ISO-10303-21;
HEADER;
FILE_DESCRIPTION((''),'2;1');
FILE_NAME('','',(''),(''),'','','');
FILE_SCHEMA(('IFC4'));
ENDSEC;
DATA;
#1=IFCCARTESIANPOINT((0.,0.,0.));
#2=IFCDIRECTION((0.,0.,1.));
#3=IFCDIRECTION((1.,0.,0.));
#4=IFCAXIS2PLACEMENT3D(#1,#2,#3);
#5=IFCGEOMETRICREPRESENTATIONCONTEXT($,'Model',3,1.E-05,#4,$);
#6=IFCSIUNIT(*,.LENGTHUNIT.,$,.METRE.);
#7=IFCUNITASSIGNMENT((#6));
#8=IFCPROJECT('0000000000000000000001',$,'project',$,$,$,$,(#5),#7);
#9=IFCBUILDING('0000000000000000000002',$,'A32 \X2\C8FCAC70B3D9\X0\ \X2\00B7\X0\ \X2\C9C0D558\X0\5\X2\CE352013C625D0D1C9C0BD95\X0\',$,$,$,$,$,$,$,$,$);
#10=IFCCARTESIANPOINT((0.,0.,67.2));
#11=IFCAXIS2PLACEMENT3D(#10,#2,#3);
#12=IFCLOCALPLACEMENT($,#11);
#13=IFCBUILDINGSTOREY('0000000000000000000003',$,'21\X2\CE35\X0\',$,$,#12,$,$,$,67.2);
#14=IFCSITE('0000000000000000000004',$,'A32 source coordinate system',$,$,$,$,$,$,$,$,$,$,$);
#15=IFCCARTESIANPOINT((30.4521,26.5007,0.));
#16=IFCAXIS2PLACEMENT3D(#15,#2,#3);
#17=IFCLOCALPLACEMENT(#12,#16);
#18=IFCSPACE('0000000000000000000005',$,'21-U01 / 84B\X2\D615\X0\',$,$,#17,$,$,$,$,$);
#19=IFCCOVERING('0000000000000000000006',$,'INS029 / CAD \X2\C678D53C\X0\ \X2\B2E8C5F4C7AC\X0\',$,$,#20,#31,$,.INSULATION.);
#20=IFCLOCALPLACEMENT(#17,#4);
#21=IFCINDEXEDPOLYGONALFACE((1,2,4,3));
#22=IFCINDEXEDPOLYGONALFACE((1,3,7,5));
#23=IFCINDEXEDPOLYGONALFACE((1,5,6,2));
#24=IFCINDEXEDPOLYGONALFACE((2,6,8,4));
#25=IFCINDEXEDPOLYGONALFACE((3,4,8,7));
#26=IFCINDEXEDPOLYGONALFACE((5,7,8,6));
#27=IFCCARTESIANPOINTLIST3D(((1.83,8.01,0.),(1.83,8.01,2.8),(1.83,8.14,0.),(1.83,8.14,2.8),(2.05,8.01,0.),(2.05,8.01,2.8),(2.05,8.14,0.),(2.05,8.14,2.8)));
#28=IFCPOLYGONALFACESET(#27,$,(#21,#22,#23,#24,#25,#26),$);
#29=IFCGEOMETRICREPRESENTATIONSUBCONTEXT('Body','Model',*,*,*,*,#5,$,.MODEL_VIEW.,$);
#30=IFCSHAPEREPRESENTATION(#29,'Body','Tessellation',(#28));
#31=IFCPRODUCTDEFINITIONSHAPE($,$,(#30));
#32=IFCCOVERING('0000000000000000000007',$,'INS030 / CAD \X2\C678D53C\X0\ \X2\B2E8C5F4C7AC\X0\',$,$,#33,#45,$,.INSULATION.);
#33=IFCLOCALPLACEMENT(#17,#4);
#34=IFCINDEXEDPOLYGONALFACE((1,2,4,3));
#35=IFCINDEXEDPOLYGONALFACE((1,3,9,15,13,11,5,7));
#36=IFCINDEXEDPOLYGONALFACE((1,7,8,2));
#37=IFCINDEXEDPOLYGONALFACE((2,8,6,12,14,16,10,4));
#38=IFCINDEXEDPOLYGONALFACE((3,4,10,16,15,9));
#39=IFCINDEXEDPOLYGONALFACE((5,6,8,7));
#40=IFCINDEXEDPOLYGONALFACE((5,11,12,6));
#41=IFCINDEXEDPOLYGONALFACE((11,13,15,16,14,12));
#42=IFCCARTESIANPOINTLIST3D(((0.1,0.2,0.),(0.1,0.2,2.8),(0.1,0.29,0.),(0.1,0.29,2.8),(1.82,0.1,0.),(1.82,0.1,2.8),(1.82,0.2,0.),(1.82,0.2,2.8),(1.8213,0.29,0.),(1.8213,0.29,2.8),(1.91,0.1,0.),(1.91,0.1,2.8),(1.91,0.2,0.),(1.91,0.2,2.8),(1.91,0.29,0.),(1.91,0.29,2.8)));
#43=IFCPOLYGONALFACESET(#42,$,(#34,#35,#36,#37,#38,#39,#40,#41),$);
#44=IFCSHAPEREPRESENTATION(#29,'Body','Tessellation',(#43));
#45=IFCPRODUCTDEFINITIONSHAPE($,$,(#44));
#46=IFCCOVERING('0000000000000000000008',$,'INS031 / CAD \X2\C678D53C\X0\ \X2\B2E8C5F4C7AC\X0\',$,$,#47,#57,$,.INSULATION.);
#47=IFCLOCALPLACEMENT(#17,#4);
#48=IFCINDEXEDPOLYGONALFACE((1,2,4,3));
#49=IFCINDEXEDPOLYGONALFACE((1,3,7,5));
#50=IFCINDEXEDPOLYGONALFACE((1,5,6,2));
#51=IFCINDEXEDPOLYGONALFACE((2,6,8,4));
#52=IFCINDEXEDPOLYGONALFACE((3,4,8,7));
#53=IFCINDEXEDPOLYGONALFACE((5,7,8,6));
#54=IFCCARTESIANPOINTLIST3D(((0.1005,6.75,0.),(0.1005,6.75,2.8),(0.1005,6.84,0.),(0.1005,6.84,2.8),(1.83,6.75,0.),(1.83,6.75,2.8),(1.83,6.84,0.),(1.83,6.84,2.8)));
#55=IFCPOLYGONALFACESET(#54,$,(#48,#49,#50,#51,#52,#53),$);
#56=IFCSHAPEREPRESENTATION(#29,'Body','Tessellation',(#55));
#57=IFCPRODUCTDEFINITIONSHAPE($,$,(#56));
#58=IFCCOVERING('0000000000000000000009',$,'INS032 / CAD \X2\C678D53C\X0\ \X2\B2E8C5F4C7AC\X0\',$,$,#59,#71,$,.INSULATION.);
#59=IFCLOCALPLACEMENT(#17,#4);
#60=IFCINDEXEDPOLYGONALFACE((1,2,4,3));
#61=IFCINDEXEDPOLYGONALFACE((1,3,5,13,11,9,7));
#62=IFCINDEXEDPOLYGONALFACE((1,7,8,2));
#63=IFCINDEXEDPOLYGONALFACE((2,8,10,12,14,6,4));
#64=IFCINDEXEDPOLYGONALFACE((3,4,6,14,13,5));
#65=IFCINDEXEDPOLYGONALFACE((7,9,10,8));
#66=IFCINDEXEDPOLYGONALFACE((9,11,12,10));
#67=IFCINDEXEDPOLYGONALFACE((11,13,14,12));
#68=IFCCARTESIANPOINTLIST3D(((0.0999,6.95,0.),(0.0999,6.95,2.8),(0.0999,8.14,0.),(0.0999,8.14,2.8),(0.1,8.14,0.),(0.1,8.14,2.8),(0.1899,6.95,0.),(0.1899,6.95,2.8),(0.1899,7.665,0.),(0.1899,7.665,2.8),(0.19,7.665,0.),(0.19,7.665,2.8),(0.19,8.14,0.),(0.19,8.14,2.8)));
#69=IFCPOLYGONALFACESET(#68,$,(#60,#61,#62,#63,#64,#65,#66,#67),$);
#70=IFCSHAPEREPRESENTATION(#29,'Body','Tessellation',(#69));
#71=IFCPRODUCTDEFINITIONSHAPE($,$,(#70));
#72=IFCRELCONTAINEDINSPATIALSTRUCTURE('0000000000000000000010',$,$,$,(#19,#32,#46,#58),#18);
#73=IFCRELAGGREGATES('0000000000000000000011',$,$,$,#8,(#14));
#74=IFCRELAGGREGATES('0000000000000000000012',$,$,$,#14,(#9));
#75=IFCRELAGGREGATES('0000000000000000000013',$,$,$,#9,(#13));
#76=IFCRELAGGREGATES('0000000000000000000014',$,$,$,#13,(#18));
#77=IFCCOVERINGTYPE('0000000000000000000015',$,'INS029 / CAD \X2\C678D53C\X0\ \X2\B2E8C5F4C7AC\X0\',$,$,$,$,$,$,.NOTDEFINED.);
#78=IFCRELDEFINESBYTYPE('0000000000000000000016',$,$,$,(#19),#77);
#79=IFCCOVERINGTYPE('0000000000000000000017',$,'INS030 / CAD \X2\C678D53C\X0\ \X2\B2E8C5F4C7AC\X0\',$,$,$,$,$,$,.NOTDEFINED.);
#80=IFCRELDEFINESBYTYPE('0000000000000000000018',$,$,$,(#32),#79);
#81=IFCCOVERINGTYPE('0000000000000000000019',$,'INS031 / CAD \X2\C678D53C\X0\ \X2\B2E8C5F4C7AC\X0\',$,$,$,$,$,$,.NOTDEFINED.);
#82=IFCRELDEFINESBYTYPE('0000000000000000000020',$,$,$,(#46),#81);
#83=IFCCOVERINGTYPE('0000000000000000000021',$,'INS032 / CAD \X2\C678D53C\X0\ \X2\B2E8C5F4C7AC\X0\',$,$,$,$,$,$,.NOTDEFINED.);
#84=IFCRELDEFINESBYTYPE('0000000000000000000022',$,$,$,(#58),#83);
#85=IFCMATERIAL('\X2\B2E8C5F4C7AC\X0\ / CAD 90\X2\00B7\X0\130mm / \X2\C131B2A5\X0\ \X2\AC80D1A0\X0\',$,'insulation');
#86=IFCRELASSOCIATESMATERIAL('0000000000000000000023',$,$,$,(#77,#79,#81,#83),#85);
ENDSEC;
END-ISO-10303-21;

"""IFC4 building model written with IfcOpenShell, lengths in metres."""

from ifc_helpers import new_model, si_unit, frame, origin, origin_with_axes, place, context, subcontext, project, spatial, polyline, outline, extrude, source, transform, mapped, material, type_object, type_shapes, element, save


model = new_model("IFC4")

# Units and contexts
model_context = context("Model", 3, precision=1e-05, world=origin_with_axes())
body_context = subcontext(model_context, "Body", "Model", "MODEL_VIEW")
ifc_project = project(units=[si_unit("LENGTHUNIT", "METRE")], contexts=[model_context])

# Site, building, storey, space
storey_placement = place(None, frame((0.0, 0.0, 67.2), z_axis=(0.0, 0.0, 1.0), x_axis=(1.0, 0.0, 0.0)))
space_placement = place(storey_placement, frame((30.4521, 26.5007, 0.0), z_axis=(0.0, 0.0, 1.0), x_axis=(1.0, 0.0, 0.0)))
site = spatial("IfcSite", under=ifc_project, Name="A32 source coordinate system")
building = spatial("IfcBuilding", under=site, Name="A32 주거동 · 지하5층–옥탑지붕")
storey = spatial("IfcBuildingStorey", under=building, at=storey_placement, Name="21층", Elevation=67.2)
space = spatial("IfcSpace", under=storey, at=space_placement, Name="21-U01 / 84B형")

# Coverings
ifc_material = material(Name="단열재 / CAD 90·130mm / 성능 검토", Category="insulation")
covering_type_1 = type_object("IfcCoveringType", Name="INS029 / CAD 외피 단열재", PredefinedType="NOTDEFINED", material=ifc_material)
shared_shape_1 = source(origin(), body_context, "Body", "SweptSolid", [
    extrude(outline(polyline([(1.83, 8.01), (1.83, 8.14), (2.05, 8.14), (2.05, 8.01), (1.83, 8.01)])), origin(), (0.0, 0.0, 1.0), 2.8),
])
type_shapes(covering_type_1, [shared_shape_1])
covering_1_placement = place(space_placement, origin_with_axes())
element("IfcCovering", 1, at=covering_1_placement, inside=space, type_object=covering_type_1, Name="INS029 / CAD 외피 단열재", PredefinedType="INSULATION", context=body_context, shape_type="MappedRepresentation", body=[
    mapped(shared_shape_1, transform((0.0, 0.0, 0.0), scale=1.0)),
])
covering_type_2 = type_object("IfcCoveringType", Name="INS030 / CAD 외피 단열재", PredefinedType="NOTDEFINED", material=ifc_material)
shared_shape_2 = source(origin(), body_context, "Body", "SweptSolid", [
    extrude(outline(polyline([(1.91, 0.2), (1.91, 0.1), (1.82, 0.1), (1.82, 0.2), (0.1, 0.2), (0.1, 0.29), (1.8213, 0.29), (1.91, 0.29), (1.91, 0.2)])), origin(), (0.0, 0.0, 1.0), 2.8),
])
type_shapes(covering_type_2, [shared_shape_2])
covering_2_placement = place(space_placement, origin_with_axes())
element("IfcCovering", 2, at=covering_2_placement, inside=space, type_object=covering_type_2, Name="INS030 / CAD 외피 단열재", PredefinedType="INSULATION", context=body_context, shape_type="MappedRepresentation", body=[
    mapped(shared_shape_2, transform((0.0, 0.0, 0.0), scale=1.0)),
])
covering_type_3 = type_object("IfcCoveringType", Name="INS031 / CAD 외피 단열재", PredefinedType="NOTDEFINED", material=ifc_material)
shared_shape_3 = source(origin(), body_context, "Body", "SweptSolid", [
    extrude(outline(polyline([(1.83, 6.75), (0.1005, 6.75), (0.1005, 6.84), (1.83, 6.84), (1.83, 6.75)])), origin(), (0.0, 0.0, 1.0), 2.8),
])
type_shapes(covering_type_3, [shared_shape_3])
covering_3_placement = place(space_placement, origin_with_axes())
element("IfcCovering", 3, at=covering_3_placement, inside=space, type_object=covering_type_3, Name="INS031 / CAD 외피 단열재", PredefinedType="INSULATION", context=body_context, shape_type="MappedRepresentation", body=[
    mapped(shared_shape_3, transform((0.0, 0.0, 0.0), scale=1.0)),
])
covering_type_4 = type_object("IfcCoveringType", Name="INS032 / CAD 외피 단열재", PredefinedType="NOTDEFINED", material=ifc_material)
shared_shape_4 = source(origin(), body_context, "Body", "SweptSolid", [
    extrude(outline(polyline([(0.1899, 6.95), (0.0999, 6.95), (0.0999, 8.14), (0.1, 8.14), (0.19, 8.14), (0.19, 7.665), (0.1899, 7.665), (0.1899, 6.95)])), origin(), (0.0, 0.0, 1.0), 2.8),
])
type_shapes(covering_type_4, [shared_shape_4])
covering_4_placement = place(space_placement, origin_with_axes())
element("IfcCovering", 4, at=covering_4_placement, inside=space, type_object=covering_type_4, Name="INS032 / CAD 외피 단열재", PredefinedType="INSULATION", context=body_context, shape_type="MappedRepresentation", body=[
    mapped(shared_shape_4, transform((0.0, 0.0, 0.0), scale=1.0)),
])

save(model, "model.ifc")
